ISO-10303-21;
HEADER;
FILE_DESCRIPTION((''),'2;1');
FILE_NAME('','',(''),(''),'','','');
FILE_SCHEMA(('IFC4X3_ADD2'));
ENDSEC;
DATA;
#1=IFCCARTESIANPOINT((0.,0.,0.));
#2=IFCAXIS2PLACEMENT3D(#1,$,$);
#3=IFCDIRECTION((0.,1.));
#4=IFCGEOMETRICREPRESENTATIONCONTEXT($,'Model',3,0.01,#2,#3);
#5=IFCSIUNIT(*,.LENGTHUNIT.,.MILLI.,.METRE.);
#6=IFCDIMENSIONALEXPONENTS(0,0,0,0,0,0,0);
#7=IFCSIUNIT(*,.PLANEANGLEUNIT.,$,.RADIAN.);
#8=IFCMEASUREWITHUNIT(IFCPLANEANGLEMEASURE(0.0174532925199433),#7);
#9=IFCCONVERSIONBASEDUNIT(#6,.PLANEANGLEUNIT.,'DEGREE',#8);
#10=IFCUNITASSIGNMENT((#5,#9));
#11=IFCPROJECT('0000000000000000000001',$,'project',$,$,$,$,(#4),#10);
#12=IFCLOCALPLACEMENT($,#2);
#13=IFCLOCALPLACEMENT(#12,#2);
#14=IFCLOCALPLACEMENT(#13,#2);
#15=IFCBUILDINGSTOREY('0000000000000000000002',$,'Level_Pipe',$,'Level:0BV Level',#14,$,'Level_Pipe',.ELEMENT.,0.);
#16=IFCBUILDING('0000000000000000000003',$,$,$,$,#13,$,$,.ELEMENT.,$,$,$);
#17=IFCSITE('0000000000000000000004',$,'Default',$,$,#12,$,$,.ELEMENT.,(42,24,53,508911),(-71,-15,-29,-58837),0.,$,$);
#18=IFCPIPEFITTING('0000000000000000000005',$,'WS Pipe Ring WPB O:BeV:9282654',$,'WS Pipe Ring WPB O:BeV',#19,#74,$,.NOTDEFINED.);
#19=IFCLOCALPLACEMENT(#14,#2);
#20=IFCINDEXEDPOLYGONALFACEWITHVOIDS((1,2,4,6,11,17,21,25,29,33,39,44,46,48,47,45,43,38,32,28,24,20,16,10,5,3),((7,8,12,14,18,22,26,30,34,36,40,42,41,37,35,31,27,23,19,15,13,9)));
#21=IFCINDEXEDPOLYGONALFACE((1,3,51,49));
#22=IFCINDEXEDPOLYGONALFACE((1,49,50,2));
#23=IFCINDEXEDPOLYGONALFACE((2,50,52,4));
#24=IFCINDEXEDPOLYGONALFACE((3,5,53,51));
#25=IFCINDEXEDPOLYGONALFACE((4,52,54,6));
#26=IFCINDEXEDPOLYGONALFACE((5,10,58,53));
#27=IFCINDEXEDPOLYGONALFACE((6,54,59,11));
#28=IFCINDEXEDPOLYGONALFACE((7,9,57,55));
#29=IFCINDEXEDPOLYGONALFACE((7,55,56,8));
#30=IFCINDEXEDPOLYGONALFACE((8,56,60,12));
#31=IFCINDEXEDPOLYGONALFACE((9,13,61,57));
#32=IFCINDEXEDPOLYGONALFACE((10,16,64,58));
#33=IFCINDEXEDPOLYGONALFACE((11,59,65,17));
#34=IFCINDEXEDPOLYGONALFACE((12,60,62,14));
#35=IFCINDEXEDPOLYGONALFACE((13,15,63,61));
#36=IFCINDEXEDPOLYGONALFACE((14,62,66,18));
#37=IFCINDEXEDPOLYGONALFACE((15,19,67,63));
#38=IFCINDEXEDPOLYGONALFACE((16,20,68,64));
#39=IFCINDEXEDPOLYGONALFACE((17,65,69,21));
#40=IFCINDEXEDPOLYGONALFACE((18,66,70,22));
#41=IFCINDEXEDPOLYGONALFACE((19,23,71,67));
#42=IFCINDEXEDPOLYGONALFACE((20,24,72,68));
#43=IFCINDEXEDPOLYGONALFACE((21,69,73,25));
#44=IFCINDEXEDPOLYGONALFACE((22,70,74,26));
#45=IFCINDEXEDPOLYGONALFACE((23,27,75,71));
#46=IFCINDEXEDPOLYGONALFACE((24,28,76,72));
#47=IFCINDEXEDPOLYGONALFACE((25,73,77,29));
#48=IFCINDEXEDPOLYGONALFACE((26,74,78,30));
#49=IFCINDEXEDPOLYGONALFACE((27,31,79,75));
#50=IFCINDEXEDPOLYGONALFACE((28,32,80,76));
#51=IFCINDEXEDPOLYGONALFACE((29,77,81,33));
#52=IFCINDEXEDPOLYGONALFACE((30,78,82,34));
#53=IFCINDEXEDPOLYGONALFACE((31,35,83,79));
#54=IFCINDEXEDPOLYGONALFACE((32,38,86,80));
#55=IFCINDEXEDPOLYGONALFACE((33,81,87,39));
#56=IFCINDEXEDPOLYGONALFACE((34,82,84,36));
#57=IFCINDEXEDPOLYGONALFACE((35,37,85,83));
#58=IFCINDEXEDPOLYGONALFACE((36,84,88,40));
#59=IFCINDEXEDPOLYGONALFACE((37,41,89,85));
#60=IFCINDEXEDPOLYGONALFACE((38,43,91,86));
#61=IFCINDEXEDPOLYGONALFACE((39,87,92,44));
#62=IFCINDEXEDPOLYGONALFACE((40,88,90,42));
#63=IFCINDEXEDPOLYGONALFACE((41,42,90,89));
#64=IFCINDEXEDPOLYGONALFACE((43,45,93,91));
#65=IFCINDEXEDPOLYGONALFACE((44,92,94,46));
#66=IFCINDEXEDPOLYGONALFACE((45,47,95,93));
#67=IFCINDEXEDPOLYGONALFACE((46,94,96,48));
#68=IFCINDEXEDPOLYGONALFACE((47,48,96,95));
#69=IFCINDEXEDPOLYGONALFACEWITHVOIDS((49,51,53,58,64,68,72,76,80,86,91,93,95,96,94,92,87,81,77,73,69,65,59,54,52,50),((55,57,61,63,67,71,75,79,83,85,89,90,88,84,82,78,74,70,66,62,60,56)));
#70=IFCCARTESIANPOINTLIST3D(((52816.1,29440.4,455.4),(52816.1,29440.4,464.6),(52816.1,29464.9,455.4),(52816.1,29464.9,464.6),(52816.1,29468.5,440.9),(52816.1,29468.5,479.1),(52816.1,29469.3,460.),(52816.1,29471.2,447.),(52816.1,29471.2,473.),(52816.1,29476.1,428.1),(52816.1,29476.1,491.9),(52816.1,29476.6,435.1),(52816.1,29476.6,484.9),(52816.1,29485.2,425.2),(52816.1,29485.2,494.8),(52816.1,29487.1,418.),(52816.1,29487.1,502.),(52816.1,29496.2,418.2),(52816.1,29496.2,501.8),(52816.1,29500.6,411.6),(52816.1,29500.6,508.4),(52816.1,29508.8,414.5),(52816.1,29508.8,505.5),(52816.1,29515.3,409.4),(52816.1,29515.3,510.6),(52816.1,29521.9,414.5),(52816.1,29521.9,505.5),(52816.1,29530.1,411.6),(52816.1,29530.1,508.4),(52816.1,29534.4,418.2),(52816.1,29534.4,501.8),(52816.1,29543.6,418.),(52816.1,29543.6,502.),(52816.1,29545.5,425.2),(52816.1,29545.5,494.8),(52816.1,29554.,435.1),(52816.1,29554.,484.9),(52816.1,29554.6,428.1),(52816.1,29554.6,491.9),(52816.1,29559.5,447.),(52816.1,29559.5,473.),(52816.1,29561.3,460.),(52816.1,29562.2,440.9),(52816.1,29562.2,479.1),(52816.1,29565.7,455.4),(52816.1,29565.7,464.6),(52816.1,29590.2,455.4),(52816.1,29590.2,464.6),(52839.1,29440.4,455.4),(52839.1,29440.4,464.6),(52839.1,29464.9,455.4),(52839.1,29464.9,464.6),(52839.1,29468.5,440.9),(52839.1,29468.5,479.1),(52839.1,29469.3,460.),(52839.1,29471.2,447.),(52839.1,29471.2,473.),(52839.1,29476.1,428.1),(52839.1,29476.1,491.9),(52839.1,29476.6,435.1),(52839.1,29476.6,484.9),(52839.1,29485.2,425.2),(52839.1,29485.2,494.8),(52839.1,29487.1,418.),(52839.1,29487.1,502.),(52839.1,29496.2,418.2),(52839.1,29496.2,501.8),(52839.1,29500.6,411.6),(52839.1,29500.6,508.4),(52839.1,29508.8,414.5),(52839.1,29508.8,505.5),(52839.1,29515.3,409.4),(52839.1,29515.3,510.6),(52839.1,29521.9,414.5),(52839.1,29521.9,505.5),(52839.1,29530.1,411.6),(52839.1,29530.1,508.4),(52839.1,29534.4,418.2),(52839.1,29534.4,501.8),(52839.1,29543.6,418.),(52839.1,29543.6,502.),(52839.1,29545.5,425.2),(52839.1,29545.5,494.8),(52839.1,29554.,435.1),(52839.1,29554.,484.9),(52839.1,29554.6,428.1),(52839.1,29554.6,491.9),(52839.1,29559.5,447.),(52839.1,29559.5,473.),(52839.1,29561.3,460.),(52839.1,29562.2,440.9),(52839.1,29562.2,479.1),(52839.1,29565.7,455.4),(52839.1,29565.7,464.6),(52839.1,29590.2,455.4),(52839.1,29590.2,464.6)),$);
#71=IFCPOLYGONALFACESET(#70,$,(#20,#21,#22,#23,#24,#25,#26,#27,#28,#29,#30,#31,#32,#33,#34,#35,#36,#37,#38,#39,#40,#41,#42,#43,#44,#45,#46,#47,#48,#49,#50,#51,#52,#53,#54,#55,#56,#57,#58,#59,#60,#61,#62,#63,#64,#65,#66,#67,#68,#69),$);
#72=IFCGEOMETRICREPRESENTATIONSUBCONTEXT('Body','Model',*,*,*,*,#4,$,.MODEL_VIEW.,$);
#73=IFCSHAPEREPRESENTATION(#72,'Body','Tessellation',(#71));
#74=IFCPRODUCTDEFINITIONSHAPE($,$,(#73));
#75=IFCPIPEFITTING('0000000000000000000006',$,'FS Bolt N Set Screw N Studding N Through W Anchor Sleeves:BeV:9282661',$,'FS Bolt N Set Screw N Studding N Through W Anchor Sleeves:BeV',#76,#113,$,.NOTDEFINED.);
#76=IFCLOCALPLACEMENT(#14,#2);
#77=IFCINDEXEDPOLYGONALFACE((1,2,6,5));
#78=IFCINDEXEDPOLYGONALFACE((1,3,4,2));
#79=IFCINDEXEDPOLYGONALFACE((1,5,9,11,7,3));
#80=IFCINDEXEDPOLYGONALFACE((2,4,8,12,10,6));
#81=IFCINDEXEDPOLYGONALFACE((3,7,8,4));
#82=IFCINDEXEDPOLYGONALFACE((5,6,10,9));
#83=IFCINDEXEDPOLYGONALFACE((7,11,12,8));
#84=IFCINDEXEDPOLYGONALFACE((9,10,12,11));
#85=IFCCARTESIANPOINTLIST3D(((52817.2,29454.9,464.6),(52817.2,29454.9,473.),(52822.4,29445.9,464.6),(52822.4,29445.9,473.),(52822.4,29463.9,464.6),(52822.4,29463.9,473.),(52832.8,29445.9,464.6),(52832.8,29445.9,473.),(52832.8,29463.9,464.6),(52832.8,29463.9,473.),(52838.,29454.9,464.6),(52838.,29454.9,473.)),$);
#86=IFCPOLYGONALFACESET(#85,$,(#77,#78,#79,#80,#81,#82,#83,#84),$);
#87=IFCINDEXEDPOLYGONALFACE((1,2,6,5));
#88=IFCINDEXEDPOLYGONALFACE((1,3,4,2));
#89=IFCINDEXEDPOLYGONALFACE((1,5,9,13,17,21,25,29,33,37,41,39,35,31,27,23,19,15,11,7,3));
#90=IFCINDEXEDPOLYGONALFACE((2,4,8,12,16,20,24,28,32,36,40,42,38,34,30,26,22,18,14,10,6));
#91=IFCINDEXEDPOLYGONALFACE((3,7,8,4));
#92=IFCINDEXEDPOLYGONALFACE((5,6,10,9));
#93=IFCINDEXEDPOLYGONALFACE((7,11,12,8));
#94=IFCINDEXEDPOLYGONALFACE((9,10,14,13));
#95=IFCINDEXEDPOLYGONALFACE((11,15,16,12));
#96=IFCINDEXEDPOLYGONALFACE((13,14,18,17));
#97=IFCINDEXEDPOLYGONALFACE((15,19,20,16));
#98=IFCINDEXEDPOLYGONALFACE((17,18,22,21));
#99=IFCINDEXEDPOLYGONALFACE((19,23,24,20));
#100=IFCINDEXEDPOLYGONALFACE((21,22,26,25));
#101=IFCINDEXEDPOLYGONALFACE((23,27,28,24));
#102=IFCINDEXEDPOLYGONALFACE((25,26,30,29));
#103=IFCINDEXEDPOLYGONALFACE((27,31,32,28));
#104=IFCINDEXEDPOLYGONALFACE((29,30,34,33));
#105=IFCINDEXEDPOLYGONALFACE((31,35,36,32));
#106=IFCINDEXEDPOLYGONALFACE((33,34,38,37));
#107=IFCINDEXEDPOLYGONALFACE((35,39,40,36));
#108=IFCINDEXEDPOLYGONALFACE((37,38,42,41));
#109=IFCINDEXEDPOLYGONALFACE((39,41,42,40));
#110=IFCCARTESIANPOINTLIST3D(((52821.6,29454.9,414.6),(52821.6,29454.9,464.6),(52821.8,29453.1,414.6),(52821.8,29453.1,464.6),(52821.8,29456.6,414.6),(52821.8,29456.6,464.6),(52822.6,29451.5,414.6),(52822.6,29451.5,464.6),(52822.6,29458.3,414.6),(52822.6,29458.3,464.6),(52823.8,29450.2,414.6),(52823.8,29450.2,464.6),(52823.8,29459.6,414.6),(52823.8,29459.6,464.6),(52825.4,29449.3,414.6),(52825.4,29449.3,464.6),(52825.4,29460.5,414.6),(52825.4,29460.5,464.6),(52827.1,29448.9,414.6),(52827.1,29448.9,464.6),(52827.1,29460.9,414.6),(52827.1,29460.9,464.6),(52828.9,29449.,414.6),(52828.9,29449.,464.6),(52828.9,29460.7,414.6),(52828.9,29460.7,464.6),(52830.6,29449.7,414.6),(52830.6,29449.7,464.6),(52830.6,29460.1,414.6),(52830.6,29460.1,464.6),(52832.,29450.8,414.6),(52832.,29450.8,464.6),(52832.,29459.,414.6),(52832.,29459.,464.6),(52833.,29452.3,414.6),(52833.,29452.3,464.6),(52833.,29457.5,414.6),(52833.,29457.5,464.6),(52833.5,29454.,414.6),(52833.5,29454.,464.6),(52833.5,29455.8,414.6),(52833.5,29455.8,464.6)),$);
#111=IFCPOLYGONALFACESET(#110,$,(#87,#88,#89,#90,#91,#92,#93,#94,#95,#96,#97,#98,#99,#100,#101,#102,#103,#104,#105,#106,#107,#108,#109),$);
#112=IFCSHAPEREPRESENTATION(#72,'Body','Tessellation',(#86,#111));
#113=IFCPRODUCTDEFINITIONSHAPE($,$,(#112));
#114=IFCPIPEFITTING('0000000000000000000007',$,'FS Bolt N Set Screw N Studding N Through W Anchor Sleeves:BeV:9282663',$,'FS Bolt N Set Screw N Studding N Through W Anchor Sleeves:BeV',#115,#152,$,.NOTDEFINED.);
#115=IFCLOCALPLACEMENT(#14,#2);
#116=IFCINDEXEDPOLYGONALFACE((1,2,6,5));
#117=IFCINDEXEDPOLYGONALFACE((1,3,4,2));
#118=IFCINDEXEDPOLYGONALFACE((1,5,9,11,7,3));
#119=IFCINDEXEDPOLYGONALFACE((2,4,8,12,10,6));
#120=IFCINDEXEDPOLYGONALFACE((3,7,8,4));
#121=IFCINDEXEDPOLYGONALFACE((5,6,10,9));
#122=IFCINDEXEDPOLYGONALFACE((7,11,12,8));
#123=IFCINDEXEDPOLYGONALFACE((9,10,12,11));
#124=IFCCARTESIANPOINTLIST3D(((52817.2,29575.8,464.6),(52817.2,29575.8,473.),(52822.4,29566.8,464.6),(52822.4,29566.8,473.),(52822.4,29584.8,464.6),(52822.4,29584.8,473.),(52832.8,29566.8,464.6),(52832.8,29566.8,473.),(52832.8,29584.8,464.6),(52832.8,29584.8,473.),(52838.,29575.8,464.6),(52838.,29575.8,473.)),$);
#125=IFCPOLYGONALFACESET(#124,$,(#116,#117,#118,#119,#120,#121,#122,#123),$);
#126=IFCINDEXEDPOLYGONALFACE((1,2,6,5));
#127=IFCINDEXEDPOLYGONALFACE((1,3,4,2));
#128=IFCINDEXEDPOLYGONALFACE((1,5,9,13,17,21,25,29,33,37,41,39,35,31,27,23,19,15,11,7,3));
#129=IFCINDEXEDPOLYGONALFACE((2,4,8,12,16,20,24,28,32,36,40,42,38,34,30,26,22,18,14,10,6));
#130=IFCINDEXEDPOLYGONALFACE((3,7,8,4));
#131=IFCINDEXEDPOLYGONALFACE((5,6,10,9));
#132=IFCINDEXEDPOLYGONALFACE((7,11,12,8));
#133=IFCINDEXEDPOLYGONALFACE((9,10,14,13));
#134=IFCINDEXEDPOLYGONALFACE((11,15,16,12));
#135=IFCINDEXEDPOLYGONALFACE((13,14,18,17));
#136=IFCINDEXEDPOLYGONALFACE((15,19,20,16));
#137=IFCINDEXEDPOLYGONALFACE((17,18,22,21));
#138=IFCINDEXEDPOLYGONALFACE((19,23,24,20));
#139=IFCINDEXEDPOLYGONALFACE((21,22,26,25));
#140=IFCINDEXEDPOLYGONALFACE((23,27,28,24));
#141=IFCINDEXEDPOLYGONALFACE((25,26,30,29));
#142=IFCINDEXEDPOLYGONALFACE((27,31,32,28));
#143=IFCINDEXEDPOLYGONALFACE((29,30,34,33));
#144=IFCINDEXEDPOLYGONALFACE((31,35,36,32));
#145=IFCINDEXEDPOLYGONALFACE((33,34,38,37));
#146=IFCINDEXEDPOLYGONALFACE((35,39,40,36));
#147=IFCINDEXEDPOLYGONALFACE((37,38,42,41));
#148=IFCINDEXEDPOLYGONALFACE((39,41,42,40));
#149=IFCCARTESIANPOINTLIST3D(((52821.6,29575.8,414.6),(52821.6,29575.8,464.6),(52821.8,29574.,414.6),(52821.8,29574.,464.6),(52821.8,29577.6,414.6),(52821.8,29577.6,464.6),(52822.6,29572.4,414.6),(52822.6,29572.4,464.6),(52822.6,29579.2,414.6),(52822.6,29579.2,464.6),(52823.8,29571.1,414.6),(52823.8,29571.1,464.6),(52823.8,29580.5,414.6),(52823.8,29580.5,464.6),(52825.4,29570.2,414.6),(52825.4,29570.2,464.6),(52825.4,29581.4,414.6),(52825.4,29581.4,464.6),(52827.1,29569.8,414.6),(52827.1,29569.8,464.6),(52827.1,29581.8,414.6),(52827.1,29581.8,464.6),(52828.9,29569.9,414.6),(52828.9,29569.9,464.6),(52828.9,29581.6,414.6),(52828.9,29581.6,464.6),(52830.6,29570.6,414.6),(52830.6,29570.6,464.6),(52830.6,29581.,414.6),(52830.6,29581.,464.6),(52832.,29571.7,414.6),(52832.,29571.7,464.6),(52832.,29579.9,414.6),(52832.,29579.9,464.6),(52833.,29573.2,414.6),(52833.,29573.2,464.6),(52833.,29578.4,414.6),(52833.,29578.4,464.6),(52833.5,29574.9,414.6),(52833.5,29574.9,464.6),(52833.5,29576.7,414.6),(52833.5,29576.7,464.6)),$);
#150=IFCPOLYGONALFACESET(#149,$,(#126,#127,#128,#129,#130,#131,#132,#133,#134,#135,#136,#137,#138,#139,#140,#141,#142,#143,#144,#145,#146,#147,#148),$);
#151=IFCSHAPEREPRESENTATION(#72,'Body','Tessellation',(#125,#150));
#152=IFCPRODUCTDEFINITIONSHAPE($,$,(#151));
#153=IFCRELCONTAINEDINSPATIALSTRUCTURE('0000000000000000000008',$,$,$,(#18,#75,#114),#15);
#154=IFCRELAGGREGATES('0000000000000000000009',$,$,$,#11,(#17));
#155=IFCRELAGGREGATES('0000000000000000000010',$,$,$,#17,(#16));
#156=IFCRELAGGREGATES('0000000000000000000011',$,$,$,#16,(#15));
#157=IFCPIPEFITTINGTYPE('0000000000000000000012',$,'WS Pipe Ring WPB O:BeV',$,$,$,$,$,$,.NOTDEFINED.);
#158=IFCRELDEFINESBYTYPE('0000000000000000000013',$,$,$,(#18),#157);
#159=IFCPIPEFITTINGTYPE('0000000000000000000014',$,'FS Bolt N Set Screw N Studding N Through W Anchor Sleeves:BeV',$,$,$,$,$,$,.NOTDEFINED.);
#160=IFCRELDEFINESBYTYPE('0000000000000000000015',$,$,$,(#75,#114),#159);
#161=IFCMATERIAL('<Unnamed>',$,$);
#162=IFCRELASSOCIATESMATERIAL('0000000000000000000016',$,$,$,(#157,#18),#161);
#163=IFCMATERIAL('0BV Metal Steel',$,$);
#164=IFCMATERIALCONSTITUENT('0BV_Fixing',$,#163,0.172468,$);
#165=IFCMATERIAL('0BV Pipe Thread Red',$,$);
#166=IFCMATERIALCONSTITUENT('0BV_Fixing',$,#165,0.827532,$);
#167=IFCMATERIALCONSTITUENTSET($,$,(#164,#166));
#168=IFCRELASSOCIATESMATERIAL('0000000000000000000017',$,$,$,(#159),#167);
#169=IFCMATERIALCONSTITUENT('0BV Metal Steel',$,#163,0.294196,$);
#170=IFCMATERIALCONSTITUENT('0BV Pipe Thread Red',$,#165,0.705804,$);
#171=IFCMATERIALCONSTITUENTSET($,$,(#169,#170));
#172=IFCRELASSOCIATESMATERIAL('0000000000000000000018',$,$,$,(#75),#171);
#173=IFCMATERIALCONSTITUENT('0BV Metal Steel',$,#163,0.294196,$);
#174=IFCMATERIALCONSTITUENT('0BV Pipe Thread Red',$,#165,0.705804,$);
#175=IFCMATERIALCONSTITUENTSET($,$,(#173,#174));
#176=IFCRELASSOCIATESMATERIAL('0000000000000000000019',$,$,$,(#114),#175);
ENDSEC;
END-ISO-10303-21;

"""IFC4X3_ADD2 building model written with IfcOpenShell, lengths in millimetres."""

from ifc_helpers import new_model, entity, si_unit, converted_unit, direction, frame, frame_2d, origin, origin_2d_with_axis, place, context, subcontext, project, spatial, polyline, circle_curve, parameter, trimmed, segment, composite_curve, circle, outline, extrude, source, transform, mapped, material, constituent, constituent_set, type_object, type_shapes, element, save


model = new_model("IFC4X3_ADD2")

# Units and contexts
model_context = context("Model", 3, precision=0.01, world=origin(), true_north=direction((0.0, 1.0)))
body_context = subcontext(model_context, "Body", "Model", "MODEL_VIEW")
ifc_project = project(units=[si_unit("LENGTHUNIT", "METRE", prefix="MILLI"), converted_unit("PLANEANGLEUNIT", "DEGREE", entity("IfcPlaneAngleMeasure", 0.0174532925199433), si_unit("PLANEANGLEUNIT", "RADIAN"), dimensions=[0, 0, 0, 0, 0, 0, 0])], contexts=[model_context])

# Site, building, storey
site_placement = place(None, origin())
site = spatial("IfcSite", under=ifc_project, at=site_placement, Name="Default", CompositionType="ELEMENT", RefLatitude=(42, 24, 53, 508911), RefLongitude=(-71, -15, -29, -58837), RefElevation=0.0)
building_placement = place(site_placement, origin())
building = spatial("IfcBuilding", under=site, at=building_placement, CompositionType="ELEMENT")
storey_placement = place(building_placement, origin())
storey = spatial("IfcBuildingStorey", under=building, at=storey_placement, Name="Level_Pipe", ObjectType="Level:0BV Level", LongName="Level_Pipe", CompositionType="ELEMENT", Elevation=0.0)

# Pipe fittings
ifc_material_1 = material(Name="0BV Metal Steel")
ifc_material_2 = material(Name="0BV Pipe Thread Red")
ifc_material_3 = material(Name="<Unnamed>")
pipe_fitting_type_1 = type_object("IfcPipeFittingType", Name="WS Pipe Ring WPB O:BeV", PredefinedType="NOTDEFINED", material=ifc_material_3)
shared_shape_1 = source(origin(), body_context, "Body", "SweptSolid", [
    extrude(outline(composite_curve([segment(trimmed(circle_curve(origin_2d_with_axis(), 50.6), [parameter(185.215909)], [parameter(354.784091)], True, "PARAMETER"), True, "CONTINUOUS"), segment(polyline([(50.4, -4.6), (74.9, -4.6)]), True, "CONTINUOUS"), segment(polyline([(74.9, -4.6), (74.9, 4.6)]), True, "CONTINUOUS"), segment(polyline([(74.9, 4.6), (50.4, 4.6)]), True, "CONTINUOUS"), segment(trimmed(circle_curve(origin_2d_with_axis(), 50.6), [parameter(5.215909)], [parameter(174.784091)], True, "PARAMETER"), True, "CONTINUOUS"), segment(polyline([(-50.4, 4.6), (-74.9, 4.6)]), True, "CONTINUOUS"), segment(polyline([(-74.9, 4.6), (-74.9, -4.6)]), True, "CONTINUOUS"), segment(polyline([(-74.9, -4.6), (-50.4, -4.6)]), True, "CONTINUOUS")], self_intersect=False), holes=[composite_curve([segment(trimmed(circle_curve(origin_2d_with_axis(), 46.0), [parameter(0.0)], [parameter(180.0)], True, "PARAMETER"), False, "CONTINUOUS"), segment(trimmed(circle_curve(origin_2d_with_axis(), 46.0), [parameter(180.0)], [parameter(360.0)], True, "PARAMETER"), False, "CONTINUOUS")], self_intersect=False)]), frame((0.0, -11.5, 0.0), z_axis=(0.0, 1.0, 0.0), x_axis=(1.0, 0.0, 0.0)), (0.0, 0.0, 1.0), 23.0),
])
type_shapes(pipe_fitting_type_1, [shared_shape_1])
pipe_fitting_1_placement = place(storey_placement, frame((52827.6, 29515.3, 460.0), z_axis=(0.0, 0.0, 1.0), x_axis=(0.0, -1.0, 0.0)))
element("IfcPipeFitting", 1, at=pipe_fitting_1_placement, inside=storey, type_object=pipe_fitting_type_1, material=ifc_material_3, Name="WS Pipe Ring WPB O:BeV:9282654", ObjectType="WS Pipe Ring WPB O:BeV", PredefinedType="NOTDEFINED", context=body_context, shape_type="MappedRepresentation", body=[
    mapped(shared_shape_1, transform((0.0, 0.0, 0.0), scale=1.0)),
])
ifc_constituent_1 = constituent(ifc_material_1, Name="0BV Metal Steel", fraction=0.294196)
ifc_constituent_2 = constituent(ifc_material_2, Name="0BV Pipe Thread Red", fraction=0.705804)
ifc_constituent_set_1 = constituent_set(constituents=[ifc_constituent_1, ifc_constituent_2])
ifc_constituent_3 = constituent(ifc_material_1, Name="0BV_Fixing", fraction=0.172468)
ifc_constituent_4 = constituent(ifc_material_2, Name="0BV_Fixing", fraction=0.827532)
ifc_constituent_set_2 = constituent_set(constituents=[ifc_constituent_3, ifc_constituent_4])
pipe_fitting_type_2 = type_object("IfcPipeFittingType", Name="FS Bolt N Set Screw N Studding N Through W Anchor Sleeves:BeV", PredefinedType="NOTDEFINED", material=ifc_constituent_set_2)
shared_shape_2 = source(origin(), body_context, "Body", "SweptSolid", [
    extrude(outline(polyline([(-5.2, -9.0), (5.2, -9.0), (10.4, 0.0), (5.2, 9.0), (-5.2, 9.0), (-10.4, 0.0), (-5.2, -9.0)])), frame((-8.4, 0.0, 0.0), z_axis=(1.0, 0.0, 0.0), x_axis=(0.0, -1.0, 0.0)), (0.0, 0.0, 1.0), 8.4),
    extrude(circle(Radius=6.0, at=frame_2d((0.0, 0.0), x_axis=(1.0, 0.0))), frame((0.0, 0.0, 0.0), z_axis=(1.0, 0.0, 0.0), x_axis=(0.0, -1.0, 0.0)), (0.0, 0.0, 1.0), 50.0),
])
type_shapes(pipe_fitting_type_2, [shared_shape_2])
pipe_fitting_2_placement = place(storey_placement, frame((52827.6, 29454.9, 464.6), z_axis=(0.0, -1.0, 0.0), x_axis=(0.0, 0.0, -1.0)))
element("IfcPipeFitting", 2, at=pipe_fitting_2_placement, inside=storey, type_object=pipe_fitting_type_2, material=ifc_constituent_set_1, Name="FS Bolt N Set Screw N Studding N Through W Anchor Sleeves:BeV:9282661", ObjectType="FS Bolt N Set Screw N Studding N Through W Anchor Sleeves:BeV", PredefinedType="NOTDEFINED", context=body_context, shape_type="MappedRepresentation", body=[
    mapped(shared_shape_2, transform((0.0, 0.0, 0.0), scale=1.0)),
])
ifc_constituent_5 = constituent(ifc_material_1, Name="0BV Metal Steel", fraction=0.294196)
ifc_constituent_6 = constituent(ifc_material_2, Name="0BV Pipe Thread Red", fraction=0.705804)
ifc_constituent_set_3 = constituent_set(constituents=[ifc_constituent_5, ifc_constituent_6])
pipe_fitting_3_placement = place(storey_placement, frame((52827.6, 29575.8, 464.6), z_axis=(0.0, -1.0, 0.0), x_axis=(0.0, 0.0, -1.0)))
element("IfcPipeFitting", 3, at=pipe_fitting_3_placement, inside=storey, type_object=pipe_fitting_type_2, material=ifc_constituent_set_3, Name="FS Bolt N Set Screw N Studding N Through W Anchor Sleeves:BeV:9282663", ObjectType="FS Bolt N Set Screw N Studding N Through W Anchor Sleeves:BeV", PredefinedType="NOTDEFINED", context=body_context, shape_type="MappedRepresentation", body=[
    mapped(shared_shape_2, transform((0.0, 0.0, 0.0), scale=1.0)),
])

save(model, "model.ifc")
